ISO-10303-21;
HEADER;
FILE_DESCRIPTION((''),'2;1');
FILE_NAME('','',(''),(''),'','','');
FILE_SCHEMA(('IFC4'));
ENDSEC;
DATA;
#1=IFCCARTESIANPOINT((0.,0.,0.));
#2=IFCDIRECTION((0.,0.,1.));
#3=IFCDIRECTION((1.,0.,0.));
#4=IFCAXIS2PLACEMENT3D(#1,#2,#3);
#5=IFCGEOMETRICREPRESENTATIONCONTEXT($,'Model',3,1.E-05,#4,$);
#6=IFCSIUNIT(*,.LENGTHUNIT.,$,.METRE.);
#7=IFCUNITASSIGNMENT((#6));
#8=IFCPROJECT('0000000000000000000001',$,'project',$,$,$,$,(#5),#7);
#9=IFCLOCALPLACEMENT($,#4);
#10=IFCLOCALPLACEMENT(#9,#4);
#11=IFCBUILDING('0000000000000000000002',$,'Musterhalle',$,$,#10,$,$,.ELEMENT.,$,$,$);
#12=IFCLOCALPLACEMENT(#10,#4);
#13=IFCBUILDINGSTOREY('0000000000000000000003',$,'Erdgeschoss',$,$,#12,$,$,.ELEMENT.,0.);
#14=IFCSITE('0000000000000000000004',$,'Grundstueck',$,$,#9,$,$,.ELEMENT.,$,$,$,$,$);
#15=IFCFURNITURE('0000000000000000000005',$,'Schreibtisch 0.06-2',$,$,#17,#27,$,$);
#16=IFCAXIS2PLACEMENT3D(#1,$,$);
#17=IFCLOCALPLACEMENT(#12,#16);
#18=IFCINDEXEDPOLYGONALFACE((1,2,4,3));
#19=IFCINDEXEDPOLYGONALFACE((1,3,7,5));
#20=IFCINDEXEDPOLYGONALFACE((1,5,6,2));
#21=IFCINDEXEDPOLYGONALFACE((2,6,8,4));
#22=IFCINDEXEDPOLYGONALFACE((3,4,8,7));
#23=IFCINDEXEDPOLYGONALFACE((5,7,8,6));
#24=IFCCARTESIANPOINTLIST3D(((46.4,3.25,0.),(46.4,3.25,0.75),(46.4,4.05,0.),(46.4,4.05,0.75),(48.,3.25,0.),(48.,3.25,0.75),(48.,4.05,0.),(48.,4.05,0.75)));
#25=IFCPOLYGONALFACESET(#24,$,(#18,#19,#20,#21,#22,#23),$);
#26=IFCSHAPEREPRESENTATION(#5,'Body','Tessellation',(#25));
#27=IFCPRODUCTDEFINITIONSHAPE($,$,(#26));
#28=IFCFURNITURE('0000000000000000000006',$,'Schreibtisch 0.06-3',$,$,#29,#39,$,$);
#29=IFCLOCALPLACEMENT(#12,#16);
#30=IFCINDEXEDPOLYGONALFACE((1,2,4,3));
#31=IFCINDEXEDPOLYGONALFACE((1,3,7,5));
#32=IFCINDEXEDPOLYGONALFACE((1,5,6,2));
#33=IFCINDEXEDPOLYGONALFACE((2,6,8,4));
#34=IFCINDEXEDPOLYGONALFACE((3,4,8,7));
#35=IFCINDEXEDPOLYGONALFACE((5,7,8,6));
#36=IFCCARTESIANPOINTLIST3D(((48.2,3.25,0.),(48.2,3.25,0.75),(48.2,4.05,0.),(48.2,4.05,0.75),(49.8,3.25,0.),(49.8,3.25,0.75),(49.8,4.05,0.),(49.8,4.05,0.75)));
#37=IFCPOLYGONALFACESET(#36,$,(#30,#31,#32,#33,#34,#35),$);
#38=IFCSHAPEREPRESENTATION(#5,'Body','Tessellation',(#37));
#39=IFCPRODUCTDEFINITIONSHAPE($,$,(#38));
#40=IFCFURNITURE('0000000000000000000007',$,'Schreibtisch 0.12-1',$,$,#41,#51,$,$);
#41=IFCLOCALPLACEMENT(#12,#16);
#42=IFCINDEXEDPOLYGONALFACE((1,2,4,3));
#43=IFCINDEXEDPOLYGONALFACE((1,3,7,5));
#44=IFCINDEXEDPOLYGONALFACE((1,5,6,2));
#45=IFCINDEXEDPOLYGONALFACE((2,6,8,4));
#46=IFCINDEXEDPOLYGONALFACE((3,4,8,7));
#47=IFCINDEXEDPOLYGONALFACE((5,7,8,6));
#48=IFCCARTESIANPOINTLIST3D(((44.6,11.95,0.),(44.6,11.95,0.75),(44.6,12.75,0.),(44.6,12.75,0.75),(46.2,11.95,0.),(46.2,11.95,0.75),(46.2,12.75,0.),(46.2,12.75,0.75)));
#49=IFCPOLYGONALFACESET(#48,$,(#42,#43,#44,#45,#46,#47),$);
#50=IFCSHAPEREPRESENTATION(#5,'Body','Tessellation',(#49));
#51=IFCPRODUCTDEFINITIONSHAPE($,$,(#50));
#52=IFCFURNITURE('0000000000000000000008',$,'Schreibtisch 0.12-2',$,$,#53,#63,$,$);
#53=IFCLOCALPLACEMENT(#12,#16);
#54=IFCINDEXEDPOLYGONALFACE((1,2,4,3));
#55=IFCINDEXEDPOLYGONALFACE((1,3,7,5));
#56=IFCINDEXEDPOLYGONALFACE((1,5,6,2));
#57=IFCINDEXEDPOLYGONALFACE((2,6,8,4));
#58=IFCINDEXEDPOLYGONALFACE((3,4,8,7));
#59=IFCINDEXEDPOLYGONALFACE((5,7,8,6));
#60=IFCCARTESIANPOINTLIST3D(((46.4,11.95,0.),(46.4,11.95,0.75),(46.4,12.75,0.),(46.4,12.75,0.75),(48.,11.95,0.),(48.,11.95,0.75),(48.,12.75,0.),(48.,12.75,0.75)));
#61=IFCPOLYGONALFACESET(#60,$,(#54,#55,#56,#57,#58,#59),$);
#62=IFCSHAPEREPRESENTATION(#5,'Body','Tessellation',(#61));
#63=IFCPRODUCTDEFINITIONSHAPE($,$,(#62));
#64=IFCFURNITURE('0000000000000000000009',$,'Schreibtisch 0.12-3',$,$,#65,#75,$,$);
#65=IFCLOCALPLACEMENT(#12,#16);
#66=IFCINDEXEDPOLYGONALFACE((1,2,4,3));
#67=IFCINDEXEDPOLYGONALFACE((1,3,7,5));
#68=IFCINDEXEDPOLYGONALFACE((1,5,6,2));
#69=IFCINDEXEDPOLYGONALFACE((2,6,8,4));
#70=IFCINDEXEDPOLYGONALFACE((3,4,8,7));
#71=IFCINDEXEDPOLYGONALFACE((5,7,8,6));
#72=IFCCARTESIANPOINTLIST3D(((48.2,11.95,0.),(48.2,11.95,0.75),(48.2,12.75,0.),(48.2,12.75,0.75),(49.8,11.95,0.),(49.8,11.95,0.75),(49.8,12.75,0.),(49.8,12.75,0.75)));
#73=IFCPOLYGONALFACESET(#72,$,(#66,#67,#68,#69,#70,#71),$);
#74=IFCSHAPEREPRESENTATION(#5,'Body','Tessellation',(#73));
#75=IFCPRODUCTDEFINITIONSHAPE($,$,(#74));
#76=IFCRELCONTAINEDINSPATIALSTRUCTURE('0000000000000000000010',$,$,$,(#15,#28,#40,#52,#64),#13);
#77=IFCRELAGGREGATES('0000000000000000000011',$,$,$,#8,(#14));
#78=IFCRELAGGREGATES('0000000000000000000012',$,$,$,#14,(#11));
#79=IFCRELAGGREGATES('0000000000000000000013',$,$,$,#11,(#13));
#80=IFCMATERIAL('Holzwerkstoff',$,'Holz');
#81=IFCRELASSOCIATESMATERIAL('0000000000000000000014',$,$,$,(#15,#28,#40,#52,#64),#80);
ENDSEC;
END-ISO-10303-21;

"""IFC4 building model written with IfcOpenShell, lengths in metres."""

from ifc_helpers import new_model, si_unit, frame, origin_with_axes, origin_2d, place, context, project, spatial, rectangle, extrude, material, element, save


model = new_model("IFC4")

# Units and contexts
model_context = context("Model", 3, precision=1e-05, world=origin_with_axes())
ifc_project = project(units=[si_unit("LENGTHUNIT", "METRE")], contexts=[model_context])

# Site, building, storey
site_placement = place(None, origin_with_axes())
site = spatial("IfcSite", under=ifc_project, at=site_placement, Name="Grundstueck", CompositionType="ELEMENT")
building_placement = place(site_placement, origin_with_axes())
building = spatial("IfcBuilding", under=site, at=building_placement, Name="Musterhalle", CompositionType="ELEMENT")
storey_placement = place(building_placement, origin_with_axes())
storey = spatial("IfcBuildingStorey", under=building, at=storey_placement, Name="Erdgeschoss", CompositionType="ELEMENT", Elevation=0.0)

# Shared definitions
placement = place(storey_placement, origin_with_axes())

# Shared definitions
ifc_material_1 = material(Name="Holzwerkstoff", Category="Holz")

# Furniture
element("IfcFurniture", 1, at=placement, inside=storey, material=ifc_material_1, Name="Schreibtisch 0.06-2", context=model_context, shape_type="SweptSolid", body=[
    extrude(rectangle(XDim=1.6, YDim=0.8, at=origin_2d()), frame((47.2, 3.65, 0.0), z_axis=(0.0, 0.0, 1.0), x_axis=(1.0, 0.0, 0.0)), (0.0, 0.0, 1.0), 0.75),
])
element("IfcFurniture", 2, at=placement, inside=storey, material=ifc_material_1, Name="Schreibtisch 0.06-3", context=model_context, shape_type="SweptSolid", body=[
    extrude(rectangle(XDim=1.6, YDim=0.8, at=origin_2d()), frame((49.0, 3.65, 0.0), z_axis=(0.0, 0.0, 1.0), x_axis=(1.0, 0.0, 0.0)), (0.0, 0.0, 1.0), 0.75),
])
element("IfcFurniture", 3, at=placement, inside=storey, material=ifc_material_1, Name="Schreibtisch 0.12-1", context=model_context, shape_type="SweptSolid", body=[
    extrude(rectangle(XDim=1.6, YDim=0.8, at=origin_2d()), frame((45.4, 12.35, 0.0), z_axis=(0.0, 0.0, 1.0), x_axis=(1.0, 0.0, 0.0)), (0.0, 0.0, 1.0), 0.75),
])
element("IfcFurniture", 4, at=placement, inside=storey, material=ifc_material_1, Name="Schreibtisch 0.12-2", context=model_context, shape_type="SweptSolid", body=[
    extrude(rectangle(XDim=1.6, YDim=0.8, at=origin_2d()), frame((47.2, 12.35, 0.0), z_axis=(0.0, 0.0, 1.0), x_axis=(1.0, 0.0, 0.0)), (0.0, 0.0, 1.0), 0.75),
])
element("IfcFurniture", 5, at=placement, inside=storey, material=ifc_material_1, Name="Schreibtisch 0.12-3", context=model_context, shape_type="SweptSolid", body=[
    extrude(rectangle(XDim=1.6, YDim=0.8, at=origin_2d()), frame((49.0, 12.35, 0.0), z_axis=(0.0, 0.0, 1.0), x_axis=(1.0, 0.0, 0.0)), (0.0, 0.0, 1.0), 0.75),
])

save(model, "model.ifc")
